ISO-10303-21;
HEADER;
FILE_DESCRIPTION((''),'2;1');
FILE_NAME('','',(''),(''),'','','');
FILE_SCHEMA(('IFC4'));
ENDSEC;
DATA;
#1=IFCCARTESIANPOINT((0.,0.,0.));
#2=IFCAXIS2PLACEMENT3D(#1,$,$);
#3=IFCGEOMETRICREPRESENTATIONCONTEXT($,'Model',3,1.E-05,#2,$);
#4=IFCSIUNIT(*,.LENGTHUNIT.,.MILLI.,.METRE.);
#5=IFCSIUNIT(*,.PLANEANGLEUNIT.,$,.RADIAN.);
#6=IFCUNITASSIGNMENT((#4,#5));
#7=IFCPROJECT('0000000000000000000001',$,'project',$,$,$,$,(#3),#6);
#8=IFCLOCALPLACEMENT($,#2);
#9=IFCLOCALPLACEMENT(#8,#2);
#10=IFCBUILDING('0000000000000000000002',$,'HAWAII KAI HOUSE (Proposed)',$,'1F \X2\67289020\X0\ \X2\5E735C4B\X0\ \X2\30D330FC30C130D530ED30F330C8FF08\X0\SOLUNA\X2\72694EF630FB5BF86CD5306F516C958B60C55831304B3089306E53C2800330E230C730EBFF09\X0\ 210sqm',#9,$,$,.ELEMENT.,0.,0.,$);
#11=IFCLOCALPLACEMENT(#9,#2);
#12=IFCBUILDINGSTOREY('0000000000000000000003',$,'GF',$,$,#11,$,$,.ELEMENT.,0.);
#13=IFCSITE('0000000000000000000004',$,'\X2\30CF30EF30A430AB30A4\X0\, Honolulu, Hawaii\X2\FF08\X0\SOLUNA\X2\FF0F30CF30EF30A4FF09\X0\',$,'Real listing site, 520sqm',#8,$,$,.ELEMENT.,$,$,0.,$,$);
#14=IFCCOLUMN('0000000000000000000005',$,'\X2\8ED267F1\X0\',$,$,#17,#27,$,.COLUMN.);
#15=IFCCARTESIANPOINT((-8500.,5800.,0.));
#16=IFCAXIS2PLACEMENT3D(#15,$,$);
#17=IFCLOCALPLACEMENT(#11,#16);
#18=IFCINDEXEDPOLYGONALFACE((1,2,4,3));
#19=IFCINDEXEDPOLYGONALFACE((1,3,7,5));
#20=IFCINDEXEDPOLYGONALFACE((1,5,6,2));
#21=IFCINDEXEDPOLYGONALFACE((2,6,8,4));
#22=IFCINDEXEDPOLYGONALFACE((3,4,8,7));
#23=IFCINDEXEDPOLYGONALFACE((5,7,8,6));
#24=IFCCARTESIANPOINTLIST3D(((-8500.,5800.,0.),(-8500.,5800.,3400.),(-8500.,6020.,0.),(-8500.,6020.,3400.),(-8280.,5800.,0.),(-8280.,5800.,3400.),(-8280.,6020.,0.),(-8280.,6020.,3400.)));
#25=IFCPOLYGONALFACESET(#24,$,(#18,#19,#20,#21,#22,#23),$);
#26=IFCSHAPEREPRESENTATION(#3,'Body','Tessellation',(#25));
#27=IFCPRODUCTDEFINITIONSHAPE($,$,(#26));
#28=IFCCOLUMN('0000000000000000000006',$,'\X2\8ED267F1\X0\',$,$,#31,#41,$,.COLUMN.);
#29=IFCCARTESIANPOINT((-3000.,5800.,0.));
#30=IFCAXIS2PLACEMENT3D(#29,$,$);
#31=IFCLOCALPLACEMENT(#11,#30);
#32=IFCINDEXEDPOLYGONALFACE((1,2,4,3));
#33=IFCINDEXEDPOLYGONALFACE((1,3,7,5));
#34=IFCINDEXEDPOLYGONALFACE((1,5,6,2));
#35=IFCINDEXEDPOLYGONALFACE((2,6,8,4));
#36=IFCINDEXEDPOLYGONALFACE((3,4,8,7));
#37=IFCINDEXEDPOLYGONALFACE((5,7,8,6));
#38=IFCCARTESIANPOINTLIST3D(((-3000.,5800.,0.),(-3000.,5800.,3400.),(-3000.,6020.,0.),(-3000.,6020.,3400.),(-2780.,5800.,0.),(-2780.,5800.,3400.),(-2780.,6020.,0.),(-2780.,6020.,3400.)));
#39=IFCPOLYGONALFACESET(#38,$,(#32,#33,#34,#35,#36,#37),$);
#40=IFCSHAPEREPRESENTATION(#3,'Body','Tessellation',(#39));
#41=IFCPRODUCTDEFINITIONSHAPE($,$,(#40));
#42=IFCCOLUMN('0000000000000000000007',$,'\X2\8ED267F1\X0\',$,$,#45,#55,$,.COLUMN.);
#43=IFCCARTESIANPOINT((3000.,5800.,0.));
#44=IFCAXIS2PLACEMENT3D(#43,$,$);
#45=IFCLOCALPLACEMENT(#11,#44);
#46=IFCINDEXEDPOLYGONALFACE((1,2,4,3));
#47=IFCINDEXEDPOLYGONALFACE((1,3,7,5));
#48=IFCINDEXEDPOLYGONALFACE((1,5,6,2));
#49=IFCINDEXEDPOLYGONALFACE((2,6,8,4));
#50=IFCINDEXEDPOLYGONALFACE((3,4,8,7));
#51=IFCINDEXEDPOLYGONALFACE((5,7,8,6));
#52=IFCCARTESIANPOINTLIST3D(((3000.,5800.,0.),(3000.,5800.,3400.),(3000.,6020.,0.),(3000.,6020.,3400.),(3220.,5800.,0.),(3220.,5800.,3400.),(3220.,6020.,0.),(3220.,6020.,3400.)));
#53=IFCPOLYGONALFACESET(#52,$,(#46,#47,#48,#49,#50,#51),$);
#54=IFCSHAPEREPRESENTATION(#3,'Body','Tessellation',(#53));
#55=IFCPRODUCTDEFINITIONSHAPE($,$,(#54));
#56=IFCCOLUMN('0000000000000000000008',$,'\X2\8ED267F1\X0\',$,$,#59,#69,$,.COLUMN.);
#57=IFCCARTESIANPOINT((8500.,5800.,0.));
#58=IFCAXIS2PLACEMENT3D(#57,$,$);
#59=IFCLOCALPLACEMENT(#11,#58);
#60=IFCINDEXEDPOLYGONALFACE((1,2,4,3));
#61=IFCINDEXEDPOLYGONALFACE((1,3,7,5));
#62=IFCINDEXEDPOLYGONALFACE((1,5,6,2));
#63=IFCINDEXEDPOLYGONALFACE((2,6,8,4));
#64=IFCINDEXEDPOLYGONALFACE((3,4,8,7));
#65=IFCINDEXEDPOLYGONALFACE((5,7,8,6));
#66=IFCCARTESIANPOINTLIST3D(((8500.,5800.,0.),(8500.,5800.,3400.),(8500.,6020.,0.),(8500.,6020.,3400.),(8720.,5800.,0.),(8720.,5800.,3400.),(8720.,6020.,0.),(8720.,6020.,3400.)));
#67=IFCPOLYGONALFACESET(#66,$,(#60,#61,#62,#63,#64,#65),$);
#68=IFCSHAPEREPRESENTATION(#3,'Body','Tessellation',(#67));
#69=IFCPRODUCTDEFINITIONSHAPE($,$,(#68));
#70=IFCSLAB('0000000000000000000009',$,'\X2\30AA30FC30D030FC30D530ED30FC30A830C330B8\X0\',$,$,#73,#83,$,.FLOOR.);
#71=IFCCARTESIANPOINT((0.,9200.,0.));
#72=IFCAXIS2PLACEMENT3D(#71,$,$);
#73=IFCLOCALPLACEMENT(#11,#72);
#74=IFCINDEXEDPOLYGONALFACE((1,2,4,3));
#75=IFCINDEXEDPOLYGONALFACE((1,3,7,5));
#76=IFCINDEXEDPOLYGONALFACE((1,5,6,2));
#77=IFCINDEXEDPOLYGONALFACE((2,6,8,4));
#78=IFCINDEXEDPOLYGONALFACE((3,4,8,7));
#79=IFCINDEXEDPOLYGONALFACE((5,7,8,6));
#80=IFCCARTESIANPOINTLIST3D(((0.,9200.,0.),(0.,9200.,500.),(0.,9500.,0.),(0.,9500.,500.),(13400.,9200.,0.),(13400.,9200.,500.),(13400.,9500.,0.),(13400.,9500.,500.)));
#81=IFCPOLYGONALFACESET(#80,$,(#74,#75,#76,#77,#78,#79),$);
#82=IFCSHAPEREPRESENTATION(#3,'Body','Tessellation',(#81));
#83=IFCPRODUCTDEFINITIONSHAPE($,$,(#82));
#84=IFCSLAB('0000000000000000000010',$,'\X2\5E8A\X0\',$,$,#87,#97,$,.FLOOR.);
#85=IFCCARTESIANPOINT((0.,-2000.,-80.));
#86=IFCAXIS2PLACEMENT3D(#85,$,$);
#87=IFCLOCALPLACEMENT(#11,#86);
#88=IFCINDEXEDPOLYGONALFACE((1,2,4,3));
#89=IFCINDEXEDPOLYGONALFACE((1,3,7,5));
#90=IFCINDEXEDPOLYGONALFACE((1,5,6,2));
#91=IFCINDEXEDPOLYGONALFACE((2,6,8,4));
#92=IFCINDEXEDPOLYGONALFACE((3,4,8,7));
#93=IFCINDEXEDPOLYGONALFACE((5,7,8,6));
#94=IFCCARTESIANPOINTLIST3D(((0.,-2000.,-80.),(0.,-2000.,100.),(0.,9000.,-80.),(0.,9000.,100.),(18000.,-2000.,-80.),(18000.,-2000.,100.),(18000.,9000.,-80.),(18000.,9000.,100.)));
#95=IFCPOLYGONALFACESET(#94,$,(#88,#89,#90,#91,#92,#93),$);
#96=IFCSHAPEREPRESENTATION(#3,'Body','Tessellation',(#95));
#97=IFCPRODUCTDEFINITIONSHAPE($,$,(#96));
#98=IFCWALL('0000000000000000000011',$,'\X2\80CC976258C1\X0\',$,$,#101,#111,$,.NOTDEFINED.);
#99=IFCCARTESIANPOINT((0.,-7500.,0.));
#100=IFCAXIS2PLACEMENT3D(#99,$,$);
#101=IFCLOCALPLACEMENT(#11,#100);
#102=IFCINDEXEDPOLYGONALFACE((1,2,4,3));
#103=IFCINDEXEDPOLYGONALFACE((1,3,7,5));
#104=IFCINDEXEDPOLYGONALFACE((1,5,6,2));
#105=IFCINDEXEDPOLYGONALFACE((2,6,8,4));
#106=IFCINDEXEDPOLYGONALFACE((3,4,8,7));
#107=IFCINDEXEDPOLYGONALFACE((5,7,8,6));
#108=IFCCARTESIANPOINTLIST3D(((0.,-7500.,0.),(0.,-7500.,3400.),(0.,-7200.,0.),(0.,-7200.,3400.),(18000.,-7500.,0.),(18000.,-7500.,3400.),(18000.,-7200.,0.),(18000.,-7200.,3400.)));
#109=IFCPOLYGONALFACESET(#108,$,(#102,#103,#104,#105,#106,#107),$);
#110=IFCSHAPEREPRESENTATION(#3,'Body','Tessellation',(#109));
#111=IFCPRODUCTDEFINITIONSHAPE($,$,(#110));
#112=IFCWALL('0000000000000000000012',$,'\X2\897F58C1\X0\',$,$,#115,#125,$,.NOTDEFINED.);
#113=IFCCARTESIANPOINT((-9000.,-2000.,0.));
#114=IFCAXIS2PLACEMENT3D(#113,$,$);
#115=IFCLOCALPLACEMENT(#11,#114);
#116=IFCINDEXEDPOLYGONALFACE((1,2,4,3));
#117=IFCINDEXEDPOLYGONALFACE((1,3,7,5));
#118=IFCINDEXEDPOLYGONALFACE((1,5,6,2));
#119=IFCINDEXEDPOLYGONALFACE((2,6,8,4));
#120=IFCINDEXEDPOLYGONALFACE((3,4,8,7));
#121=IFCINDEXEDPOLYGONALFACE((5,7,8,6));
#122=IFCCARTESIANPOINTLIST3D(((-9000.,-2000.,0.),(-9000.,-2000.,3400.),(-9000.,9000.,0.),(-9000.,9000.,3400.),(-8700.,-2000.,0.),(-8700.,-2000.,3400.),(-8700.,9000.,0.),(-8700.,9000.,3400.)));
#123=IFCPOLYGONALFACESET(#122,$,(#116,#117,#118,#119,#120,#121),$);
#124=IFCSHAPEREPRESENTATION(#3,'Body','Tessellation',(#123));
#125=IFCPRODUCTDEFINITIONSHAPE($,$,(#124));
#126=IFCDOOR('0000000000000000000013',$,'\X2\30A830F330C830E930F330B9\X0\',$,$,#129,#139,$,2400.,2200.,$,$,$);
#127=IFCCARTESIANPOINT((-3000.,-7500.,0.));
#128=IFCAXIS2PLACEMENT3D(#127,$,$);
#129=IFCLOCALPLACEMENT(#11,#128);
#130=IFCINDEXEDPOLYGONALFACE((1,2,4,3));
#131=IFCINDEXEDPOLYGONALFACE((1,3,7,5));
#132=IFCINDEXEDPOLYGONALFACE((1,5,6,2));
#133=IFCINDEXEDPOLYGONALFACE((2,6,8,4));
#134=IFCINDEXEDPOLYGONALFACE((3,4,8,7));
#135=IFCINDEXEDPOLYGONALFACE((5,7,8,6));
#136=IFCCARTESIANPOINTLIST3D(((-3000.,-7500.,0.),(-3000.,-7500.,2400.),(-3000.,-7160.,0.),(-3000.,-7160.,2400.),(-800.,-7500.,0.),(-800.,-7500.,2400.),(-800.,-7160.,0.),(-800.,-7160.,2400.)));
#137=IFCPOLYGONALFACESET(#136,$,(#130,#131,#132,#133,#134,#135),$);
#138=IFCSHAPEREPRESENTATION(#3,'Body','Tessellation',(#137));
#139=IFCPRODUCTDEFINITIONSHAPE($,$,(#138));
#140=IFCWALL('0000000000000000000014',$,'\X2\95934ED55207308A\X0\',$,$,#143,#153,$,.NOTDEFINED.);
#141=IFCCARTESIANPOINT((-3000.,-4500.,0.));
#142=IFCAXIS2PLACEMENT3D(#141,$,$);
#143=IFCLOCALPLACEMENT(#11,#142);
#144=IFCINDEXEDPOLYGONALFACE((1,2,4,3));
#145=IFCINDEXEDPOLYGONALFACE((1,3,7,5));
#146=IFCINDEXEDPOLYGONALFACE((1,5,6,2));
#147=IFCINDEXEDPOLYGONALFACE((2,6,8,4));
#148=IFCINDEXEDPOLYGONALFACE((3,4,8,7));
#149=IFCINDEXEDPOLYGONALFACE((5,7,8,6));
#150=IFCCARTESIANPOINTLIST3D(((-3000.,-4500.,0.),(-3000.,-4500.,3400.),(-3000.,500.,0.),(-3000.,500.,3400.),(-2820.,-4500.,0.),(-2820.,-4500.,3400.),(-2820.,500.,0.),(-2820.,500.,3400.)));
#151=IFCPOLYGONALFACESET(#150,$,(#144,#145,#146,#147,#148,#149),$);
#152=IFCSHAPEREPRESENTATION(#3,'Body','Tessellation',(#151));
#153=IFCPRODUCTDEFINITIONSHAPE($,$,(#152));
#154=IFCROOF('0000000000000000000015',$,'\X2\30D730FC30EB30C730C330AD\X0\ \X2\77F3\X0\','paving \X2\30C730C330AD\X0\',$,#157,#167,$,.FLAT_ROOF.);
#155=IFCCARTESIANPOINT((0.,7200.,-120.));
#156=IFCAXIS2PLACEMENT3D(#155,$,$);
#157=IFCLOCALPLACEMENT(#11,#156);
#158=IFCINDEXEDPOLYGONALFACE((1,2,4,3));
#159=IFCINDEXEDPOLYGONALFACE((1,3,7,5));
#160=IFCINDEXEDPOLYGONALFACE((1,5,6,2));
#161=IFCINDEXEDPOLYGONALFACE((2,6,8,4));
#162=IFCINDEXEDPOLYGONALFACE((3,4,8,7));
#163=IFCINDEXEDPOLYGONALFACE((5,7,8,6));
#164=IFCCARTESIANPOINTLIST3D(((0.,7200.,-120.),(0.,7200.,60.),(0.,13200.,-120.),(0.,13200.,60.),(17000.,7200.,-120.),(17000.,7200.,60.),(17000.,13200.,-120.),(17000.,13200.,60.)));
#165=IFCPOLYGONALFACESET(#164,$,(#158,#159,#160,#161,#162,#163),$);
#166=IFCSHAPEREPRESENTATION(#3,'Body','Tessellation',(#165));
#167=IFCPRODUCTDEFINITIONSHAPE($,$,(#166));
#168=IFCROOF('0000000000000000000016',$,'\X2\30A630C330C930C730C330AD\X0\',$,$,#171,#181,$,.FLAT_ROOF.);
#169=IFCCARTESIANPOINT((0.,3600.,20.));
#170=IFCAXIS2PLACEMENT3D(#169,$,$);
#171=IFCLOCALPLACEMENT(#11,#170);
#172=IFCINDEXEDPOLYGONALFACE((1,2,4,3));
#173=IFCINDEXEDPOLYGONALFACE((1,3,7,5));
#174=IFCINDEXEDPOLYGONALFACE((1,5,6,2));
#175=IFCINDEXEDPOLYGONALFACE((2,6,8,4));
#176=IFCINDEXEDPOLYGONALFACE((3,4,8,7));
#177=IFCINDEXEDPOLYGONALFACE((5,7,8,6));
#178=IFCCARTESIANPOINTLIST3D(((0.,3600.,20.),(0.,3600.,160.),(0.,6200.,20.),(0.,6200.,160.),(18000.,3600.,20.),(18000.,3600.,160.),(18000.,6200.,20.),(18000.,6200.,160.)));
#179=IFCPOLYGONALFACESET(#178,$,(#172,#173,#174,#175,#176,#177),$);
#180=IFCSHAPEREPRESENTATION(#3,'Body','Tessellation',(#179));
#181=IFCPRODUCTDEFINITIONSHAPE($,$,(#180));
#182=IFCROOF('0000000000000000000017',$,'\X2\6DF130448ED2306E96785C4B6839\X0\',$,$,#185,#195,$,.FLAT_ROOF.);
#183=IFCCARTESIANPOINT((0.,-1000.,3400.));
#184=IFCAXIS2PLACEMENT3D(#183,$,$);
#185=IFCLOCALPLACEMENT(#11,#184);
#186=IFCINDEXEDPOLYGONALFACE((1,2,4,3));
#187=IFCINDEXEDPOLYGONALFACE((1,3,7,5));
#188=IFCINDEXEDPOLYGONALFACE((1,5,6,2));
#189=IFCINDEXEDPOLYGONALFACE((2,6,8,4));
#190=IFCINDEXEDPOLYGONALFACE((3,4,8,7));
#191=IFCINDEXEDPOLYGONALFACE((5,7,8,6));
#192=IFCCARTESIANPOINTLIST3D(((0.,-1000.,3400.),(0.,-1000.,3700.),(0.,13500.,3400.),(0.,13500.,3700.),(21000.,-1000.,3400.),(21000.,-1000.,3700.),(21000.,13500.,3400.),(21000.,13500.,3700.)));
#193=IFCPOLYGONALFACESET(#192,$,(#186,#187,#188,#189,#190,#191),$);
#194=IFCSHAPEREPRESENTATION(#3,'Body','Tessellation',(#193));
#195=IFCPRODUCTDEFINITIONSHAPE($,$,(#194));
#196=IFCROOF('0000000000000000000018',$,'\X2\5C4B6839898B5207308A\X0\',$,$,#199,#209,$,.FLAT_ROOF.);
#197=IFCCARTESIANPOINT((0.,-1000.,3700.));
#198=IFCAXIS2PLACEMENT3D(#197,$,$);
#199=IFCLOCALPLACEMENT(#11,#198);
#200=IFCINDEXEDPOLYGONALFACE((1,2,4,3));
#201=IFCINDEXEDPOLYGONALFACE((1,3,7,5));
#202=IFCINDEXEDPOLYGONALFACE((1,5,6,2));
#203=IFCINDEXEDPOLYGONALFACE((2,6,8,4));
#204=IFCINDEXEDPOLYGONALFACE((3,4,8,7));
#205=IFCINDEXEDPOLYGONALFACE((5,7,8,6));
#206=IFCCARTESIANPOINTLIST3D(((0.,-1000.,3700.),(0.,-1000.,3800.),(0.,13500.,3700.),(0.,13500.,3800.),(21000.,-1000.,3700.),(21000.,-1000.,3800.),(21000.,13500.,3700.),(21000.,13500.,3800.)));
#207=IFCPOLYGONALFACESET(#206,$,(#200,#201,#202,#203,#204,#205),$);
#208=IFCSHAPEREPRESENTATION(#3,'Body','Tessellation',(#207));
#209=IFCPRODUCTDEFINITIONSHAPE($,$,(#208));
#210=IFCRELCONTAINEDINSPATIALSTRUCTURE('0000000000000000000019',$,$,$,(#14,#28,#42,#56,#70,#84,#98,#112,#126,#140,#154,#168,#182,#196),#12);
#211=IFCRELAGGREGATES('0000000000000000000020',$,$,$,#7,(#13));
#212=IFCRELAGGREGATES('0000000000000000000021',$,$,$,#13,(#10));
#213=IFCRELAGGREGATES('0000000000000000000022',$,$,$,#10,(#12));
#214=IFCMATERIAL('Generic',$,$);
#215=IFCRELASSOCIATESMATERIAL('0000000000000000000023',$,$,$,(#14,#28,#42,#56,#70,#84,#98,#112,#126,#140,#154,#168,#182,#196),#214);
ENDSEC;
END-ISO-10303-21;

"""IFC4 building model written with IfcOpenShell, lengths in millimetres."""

from ifc_helpers import new_model, si_unit, frame, frame_2d, origin, place, context, project, spatial, rectangle, extrude, material, element, save


model = new_model("IFC4")

# Units and contexts
model_context = context("Model", 3, precision=1e-05, world=origin())
ifc_project = project(units=[si_unit("LENGTHUNIT", "METRE", prefix="MILLI"), si_unit("PLANEANGLEUNIT", "RADIAN")], contexts=[model_context])

# Site, building, storey
site_placement = place(None, origin())
site = spatial("IfcSite", under=ifc_project, at=site_placement, Name="ハワイカイ, Honolulu, Hawaii（SOLUNA／ハワイ）", ObjectType="Real listing site, 520sqm", CompositionType="ELEMENT", RefElevation=0.0)
building_placement = place(site_placement, origin())
building = spatial("IfcBuilding", under=site, at=building_placement, Name="HAWAII KAI HOUSE (Proposed)", ObjectType="1F 木造 平屋 ビーチフロント（SOLUNA物件・寸法は公開情報からの参考モデル） 210sqm", CompositionType="ELEMENT", ElevationOfRefHeight=0.0, ElevationOfTerrain=0.0)
storey_placement = place(building_placement, origin())
storey = spatial("IfcBuildingStorey", under=building, at=storey_placement, Name="GF", CompositionType="ELEMENT", Elevation=0.0)

# Columns
ifc_material_1 = material(Name="Generic")
column_1_placement = place(storey_placement, frame((-8500.0, 5800.0, 0.0)))
element("IfcColumn", 1, at=column_1_placement, inside=storey, material=ifc_material_1, Name="軒柱", PredefinedType="COLUMN", context=model_context, shape_type="SweptSolid", body=[
    extrude(rectangle(XDim=220.0, YDim=220.0, at=frame_2d((110.0, 110.0))), frame((-8500.0, 5800.0, 0.0)), (0.0, 0.0, 1.0), 3400.0),
])
column_2_placement = place(storey_placement, frame((-3000.0, 5800.0, 0.0)))
element("IfcColumn", 2, at=column_2_placement, inside=storey, material=ifc_material_1, Name="軒柱", PredefinedType="COLUMN", context=model_context, shape_type="SweptSolid", body=[
    extrude(rectangle(XDim=220.0, YDim=220.0, at=frame_2d((110.0, 110.0))), frame((-3000.0, 5800.0, 0.0)), (0.0, 0.0, 1.0), 3400.0),
])
column_3_placement = place(storey_placement, frame((3000.0, 5800.0, 0.0)))
element("IfcColumn", 3, at=column_3_placement, inside=storey, material=ifc_material_1, Name="軒柱", PredefinedType="COLUMN", context=model_context, shape_type="SweptSolid", body=[
    extrude(rectangle(XDim=220.0, YDim=220.0, at=frame_2d((110.0, 110.0))), frame((3000.0, 5800.0, 0.0)), (0.0, 0.0, 1.0), 3400.0),
])
column_4_placement = place(storey_placement, frame((8500.0, 5800.0, 0.0)))
element("IfcColumn", 4, at=column_4_placement, inside=storey, material=ifc_material_1, Name="軒柱", PredefinedType="COLUMN", context=model_context, shape_type="SweptSolid", body=[
    extrude(rectangle(XDim=220.0, YDim=220.0, at=frame_2d((110.0, 110.0))), frame((8500.0, 5800.0, 0.0)), (0.0, 0.0, 1.0), 3400.0),
])

# Slabs
slab_1_placement = place(storey_placement, frame((0.0, 9200.0, 0.0)))
element("IfcSlab", 5, at=slab_1_placement, inside=storey, material=ifc_material_1, Name="オーバーフローエッジ", PredefinedType="FLOOR", context=model_context, shape_type="SweptSolid", body=[
    extrude(rectangle(XDim=13400.0, YDim=300.0, at=frame_2d((6700.0, 150.0))), frame((0.0, 9200.0, 0.0)), (0.0, 0.0, 1.0), 500.0),
])
slab_2_placement = place(storey_placement, frame((0.0, -2000.0, -80.0)))
element("IfcSlab", 6, at=slab_2_placement, inside=storey, material=ifc_material_1, Name="床", PredefinedType="FLOOR", context=model_context, shape_type="SweptSolid", body=[
    extrude(rectangle(XDim=18000.0, YDim=11000.0, at=frame_2d((9000.0, 5500.0))), frame((0.0, -2000.0, -80.0)), (0.0, 0.0, 1.0), 180.0),
])

# Walls
wall_1_placement = place(storey_placement, frame((0.0, -7500.0, 0.0)))
element("IfcWall", 7, at=wall_1_placement, inside=storey, material=ifc_material_1, Name="背面壁", PredefinedType="NOTDEFINED", context=model_context, shape_type="SweptSolid", body=[
    extrude(rectangle(XDim=18000.0, YDim=300.0, at=frame_2d((9000.0, 150.0))), frame((0.0, -7500.0, 0.0)), (0.0, 0.0, 1.0), 3400.0),
])
wall_2_placement = place(storey_placement, frame((-9000.0, -2000.0, 0.0)))
element("IfcWall", 8, at=wall_2_placement, inside=storey, material=ifc_material_1, Name="西壁", PredefinedType="NOTDEFINED", context=model_context, shape_type="SweptSolid", body=[
    extrude(rectangle(XDim=300.0, YDim=11000.0, at=frame_2d((150.0, 5500.0))), frame((-9000.0, -2000.0, 0.0)), (0.0, 0.0, 1.0), 3400.0),
])

# Door
door_placement = place(storey_placement, frame((-3000.0, -7500.0, 0.0)))
element("IfcDoor", 9, at=door_placement, inside=storey, material=ifc_material_1, Name="エントランス", OverallHeight=2400.0, OverallWidth=2200.0, context=model_context, shape_type="SweptSolid", body=[
    extrude(rectangle(XDim=2200.0, YDim=340.0, at=frame_2d((1100.0, 170.0))), frame((-3000.0, -7500.0, 0.0)), (0.0, 0.0, 1.0), 2400.0),
])

# Wall
wall_3_placement = place(storey_placement, frame((-3000.0, -4500.0, 0.0)))
element("IfcWall", 10, at=wall_3_placement, inside=storey, material=ifc_material_1, Name="間仕切り", PredefinedType="NOTDEFINED", context=model_context, shape_type="SweptSolid", body=[
    extrude(rectangle(XDim=180.0, YDim=5000.0, at=frame_2d((90.0, 2500.0))), frame((-3000.0, -4500.0, 0.0)), (0.0, 0.0, 1.0), 3400.0),
])

# Roofs
roof_1_placement = place(storey_placement, frame((0.0, 7200.0, -120.0)))
element("IfcRoof", 11, at=roof_1_placement, inside=storey, material=ifc_material_1, Name="プールデッキ 石", Description="paving デッキ", PredefinedType="FLAT_ROOF", context=model_context, shape_type="SweptSolid", body=[
    extrude(rectangle(XDim=17000.0, YDim=6000.0, at=frame_2d((8500.0, 3000.0))), frame((0.0, 7200.0, -120.0)), (0.0, 0.0, 1.0), 180.0),
])
roof_2_placement = place(storey_placement, frame((0.0, 3600.0, 20.0)))
element("IfcRoof", 12, at=roof_2_placement, inside=storey, material=ifc_material_1, Name="ウッドデッキ", PredefinedType="FLAT_ROOF", context=model_context, shape_type="SweptSolid", body=[
    extrude(rectangle(XDim=18000.0, YDim=2600.0, at=frame_2d((9000.0, 1300.0))), frame((0.0, 3600.0, 20.0)), (0.0, 0.0, 1.0), 140.0),
])
roof_3_placement = place(storey_placement, frame((0.0, -1000.0, 3400.0)))
element("IfcRoof", 13, at=roof_3_placement, inside=storey, material=ifc_material_1, Name="深い軒の陸屋根", PredefinedType="FLAT_ROOF", context=model_context, shape_type="SweptSolid", body=[
    extrude(rectangle(XDim=21000.0, YDim=14500.0, at=frame_2d((10500.0, 7250.0))), frame((0.0, -1000.0, 3400.0)), (0.0, 0.0, 1.0), 300.0),
])
roof_4_placement = place(storey_placement, frame((0.0, -1000.0, 3700.0)))
element("IfcRoof", 14, at=roof_4_placement, inside=storey, material=ifc_material_1, Name="屋根見切り", PredefinedType="FLAT_ROOF", context=model_context, shape_type="SweptSolid", body=[
    extrude(rectangle(XDim=21000.0, YDim=14500.0, at=frame_2d((10500.0, 7250.0))), frame((0.0, -1000.0, 3700.0)), (0.0, 0.0, 1.0), 100.0),
])

save(model, "model.ifc")
